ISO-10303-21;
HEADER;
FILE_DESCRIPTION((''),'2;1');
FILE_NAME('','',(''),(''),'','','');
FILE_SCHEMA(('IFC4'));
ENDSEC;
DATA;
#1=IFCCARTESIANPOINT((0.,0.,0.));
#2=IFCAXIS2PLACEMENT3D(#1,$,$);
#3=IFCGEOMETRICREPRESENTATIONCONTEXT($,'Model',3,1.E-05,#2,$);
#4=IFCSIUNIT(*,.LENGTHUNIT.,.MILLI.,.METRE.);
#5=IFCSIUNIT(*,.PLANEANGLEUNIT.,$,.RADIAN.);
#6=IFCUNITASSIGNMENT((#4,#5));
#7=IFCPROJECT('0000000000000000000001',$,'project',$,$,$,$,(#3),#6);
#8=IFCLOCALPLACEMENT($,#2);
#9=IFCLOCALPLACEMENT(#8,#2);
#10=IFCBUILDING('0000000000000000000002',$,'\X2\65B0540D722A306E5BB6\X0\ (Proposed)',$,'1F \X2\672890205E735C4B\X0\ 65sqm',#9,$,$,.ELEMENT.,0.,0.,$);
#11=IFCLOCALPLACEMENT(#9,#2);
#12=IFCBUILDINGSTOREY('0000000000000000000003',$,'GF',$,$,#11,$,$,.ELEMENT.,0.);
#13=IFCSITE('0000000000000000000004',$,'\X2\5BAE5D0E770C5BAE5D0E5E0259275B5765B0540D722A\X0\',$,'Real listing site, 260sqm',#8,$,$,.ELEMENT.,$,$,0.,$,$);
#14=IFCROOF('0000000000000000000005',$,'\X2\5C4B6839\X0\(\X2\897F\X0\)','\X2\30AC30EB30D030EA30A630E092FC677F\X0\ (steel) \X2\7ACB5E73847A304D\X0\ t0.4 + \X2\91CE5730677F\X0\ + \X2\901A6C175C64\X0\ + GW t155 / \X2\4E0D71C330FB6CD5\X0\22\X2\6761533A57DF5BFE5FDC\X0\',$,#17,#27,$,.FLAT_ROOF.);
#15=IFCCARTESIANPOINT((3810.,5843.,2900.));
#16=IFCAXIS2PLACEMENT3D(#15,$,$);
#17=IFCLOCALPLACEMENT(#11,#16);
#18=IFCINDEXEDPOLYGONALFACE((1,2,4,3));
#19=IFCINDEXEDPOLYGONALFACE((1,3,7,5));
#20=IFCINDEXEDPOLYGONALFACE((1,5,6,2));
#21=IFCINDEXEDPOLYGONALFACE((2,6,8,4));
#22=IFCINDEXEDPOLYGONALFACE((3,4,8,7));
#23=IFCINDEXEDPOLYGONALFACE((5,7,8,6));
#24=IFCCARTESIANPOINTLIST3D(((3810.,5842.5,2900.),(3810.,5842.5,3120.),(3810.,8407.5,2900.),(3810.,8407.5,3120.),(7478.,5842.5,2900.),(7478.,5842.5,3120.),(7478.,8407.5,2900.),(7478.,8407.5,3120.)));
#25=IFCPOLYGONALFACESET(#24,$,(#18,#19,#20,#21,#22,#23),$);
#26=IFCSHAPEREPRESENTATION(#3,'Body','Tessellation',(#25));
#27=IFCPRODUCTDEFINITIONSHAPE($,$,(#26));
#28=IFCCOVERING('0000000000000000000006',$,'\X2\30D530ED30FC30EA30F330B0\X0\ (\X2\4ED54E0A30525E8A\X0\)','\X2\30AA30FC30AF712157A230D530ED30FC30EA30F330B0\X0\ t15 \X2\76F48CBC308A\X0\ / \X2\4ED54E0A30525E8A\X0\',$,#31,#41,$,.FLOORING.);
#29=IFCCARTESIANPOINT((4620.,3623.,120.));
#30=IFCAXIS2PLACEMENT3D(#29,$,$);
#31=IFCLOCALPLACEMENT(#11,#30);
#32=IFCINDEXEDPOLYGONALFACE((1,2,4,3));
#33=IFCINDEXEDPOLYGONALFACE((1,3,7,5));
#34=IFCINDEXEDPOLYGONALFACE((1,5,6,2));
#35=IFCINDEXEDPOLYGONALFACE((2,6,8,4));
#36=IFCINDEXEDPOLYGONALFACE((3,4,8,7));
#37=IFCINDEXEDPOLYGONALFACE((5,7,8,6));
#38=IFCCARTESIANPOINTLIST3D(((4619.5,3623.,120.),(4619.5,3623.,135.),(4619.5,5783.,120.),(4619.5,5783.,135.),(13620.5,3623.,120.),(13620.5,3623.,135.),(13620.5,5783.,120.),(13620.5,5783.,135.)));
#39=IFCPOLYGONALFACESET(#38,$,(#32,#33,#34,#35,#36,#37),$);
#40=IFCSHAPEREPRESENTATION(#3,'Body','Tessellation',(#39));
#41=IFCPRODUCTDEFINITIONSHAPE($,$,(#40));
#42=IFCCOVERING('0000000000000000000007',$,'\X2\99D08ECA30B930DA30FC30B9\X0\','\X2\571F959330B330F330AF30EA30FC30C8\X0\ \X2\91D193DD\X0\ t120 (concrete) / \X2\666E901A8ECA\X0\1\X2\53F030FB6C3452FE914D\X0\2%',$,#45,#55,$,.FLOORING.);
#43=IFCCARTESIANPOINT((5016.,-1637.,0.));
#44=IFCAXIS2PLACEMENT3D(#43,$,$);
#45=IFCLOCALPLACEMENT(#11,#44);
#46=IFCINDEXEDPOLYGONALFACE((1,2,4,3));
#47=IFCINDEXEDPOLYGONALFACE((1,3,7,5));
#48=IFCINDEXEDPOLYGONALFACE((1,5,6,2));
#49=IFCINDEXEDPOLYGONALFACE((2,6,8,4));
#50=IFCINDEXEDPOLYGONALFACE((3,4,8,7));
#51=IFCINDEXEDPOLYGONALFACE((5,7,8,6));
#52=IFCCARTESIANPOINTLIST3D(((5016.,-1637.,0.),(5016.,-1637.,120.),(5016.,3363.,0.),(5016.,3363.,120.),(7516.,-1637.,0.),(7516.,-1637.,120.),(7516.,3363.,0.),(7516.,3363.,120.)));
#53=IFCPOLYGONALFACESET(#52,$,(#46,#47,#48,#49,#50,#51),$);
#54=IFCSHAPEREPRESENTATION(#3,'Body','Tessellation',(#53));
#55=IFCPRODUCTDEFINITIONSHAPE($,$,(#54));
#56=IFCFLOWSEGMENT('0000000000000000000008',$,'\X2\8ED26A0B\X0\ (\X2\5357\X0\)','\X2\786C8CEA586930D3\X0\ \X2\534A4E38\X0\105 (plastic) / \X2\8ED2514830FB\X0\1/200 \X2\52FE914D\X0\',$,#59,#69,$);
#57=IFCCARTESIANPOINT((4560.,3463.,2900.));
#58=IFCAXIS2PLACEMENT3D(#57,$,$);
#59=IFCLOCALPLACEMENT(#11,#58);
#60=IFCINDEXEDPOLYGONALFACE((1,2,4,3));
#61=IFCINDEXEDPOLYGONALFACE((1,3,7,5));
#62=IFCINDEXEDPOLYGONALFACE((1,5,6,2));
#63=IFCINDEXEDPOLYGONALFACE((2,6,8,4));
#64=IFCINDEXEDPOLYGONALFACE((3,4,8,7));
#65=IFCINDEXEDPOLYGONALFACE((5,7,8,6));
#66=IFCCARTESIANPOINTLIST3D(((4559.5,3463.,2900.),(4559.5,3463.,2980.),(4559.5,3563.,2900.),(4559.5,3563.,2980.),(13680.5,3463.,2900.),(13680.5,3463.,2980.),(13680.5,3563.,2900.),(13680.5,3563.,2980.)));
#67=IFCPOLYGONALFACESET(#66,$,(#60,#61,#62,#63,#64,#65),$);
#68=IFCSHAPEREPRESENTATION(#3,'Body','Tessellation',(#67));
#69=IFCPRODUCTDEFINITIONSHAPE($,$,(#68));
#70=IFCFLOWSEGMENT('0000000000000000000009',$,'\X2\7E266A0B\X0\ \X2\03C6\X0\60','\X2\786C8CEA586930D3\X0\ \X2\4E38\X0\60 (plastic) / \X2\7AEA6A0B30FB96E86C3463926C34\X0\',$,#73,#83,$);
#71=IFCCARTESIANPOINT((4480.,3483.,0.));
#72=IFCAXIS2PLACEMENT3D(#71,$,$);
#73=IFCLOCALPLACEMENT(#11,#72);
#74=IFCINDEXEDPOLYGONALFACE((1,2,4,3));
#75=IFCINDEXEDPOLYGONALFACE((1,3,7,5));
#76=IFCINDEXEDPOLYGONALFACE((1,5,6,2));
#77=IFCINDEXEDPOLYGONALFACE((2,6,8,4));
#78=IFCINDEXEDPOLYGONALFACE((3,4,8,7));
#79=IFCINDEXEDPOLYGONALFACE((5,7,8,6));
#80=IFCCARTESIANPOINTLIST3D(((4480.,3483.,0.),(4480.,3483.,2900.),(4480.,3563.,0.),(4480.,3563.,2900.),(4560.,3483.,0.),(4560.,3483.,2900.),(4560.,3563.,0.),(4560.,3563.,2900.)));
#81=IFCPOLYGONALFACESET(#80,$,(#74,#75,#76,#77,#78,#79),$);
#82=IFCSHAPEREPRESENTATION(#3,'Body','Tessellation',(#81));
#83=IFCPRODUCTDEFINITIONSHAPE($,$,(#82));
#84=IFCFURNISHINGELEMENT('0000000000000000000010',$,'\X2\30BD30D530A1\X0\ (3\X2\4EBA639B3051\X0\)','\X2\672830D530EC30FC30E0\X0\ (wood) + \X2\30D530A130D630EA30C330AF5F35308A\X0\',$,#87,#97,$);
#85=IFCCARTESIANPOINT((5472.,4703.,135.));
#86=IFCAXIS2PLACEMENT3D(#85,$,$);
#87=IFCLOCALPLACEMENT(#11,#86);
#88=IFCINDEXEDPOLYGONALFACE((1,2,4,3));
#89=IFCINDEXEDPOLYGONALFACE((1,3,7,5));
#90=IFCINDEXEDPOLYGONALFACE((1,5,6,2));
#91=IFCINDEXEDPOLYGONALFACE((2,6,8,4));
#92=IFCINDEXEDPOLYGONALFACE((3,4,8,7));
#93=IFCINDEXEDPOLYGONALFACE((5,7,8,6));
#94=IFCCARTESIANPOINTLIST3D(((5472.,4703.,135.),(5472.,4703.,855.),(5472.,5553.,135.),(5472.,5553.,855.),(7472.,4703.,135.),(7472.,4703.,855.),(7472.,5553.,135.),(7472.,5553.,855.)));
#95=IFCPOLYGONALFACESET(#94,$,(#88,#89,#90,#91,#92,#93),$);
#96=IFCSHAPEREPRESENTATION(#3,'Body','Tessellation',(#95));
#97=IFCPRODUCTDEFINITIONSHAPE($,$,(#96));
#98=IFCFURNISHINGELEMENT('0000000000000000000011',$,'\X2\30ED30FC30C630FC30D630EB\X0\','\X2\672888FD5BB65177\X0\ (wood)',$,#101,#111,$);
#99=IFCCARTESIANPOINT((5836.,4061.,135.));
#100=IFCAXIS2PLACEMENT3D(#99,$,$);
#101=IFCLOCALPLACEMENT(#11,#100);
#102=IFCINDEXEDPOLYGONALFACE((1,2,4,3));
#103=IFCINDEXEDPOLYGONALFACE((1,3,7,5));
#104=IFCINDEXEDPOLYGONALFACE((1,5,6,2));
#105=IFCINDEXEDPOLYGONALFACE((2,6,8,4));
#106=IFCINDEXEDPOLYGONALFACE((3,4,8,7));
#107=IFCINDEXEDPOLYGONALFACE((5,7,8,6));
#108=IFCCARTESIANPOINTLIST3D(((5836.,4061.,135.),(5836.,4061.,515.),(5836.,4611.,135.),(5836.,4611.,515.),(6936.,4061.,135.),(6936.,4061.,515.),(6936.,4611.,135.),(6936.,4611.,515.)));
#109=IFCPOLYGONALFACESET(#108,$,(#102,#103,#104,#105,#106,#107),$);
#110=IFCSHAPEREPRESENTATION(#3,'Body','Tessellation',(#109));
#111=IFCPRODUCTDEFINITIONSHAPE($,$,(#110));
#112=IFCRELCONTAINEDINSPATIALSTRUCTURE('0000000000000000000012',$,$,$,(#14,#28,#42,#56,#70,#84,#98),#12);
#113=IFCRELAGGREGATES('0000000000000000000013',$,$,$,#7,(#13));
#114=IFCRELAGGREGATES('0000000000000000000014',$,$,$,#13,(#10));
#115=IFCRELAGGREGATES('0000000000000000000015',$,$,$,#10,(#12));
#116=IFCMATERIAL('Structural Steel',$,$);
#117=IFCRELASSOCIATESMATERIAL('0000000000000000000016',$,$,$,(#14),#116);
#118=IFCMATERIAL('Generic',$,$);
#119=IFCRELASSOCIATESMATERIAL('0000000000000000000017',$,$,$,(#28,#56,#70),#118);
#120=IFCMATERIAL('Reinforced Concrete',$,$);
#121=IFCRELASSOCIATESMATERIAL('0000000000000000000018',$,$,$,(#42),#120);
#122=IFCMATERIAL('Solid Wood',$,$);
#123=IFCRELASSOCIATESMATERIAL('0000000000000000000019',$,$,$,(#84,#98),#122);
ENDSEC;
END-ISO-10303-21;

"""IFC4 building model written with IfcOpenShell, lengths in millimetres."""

from ifc_helpers import new_model, si_unit, frame, frame_2d, origin, place, context, project, spatial, rectangle, extrude, material, element, save


model = new_model("IFC4")

# Units and contexts
model_context = context("Model", 3, precision=1e-05, world=origin())
ifc_project = project(units=[si_unit("LENGTHUNIT", "METRE", prefix="MILLI"), si_unit("PLANEANGLEUNIT", "RADIAN")], contexts=[model_context])

# Site, building, storey
site_placement = place(None, origin())
site = spatial("IfcSite", under=ifc_project, at=site_placement, Name="宮崎県宮崎市大字新名爪", ObjectType="Real listing site, 260sqm", CompositionType="ELEMENT", RefElevation=0.0)
building_placement = place(site_placement, origin())
building = spatial("IfcBuilding", under=site, at=building_placement, Name="新名爪の家 (Proposed)", ObjectType="1F 木造平屋 65sqm", CompositionType="ELEMENT", ElevationOfRefHeight=0.0, ElevationOfTerrain=0.0)
storey_placement = place(building_placement, origin())
storey = spatial("IfcBuildingStorey", under=building, at=storey_placement, Name="GF", CompositionType="ELEMENT", Elevation=0.0)

# Shared definitions
ifc_material_1 = material(Name="Solid Wood")

# Shared definitions
ifc_material_2 = material(Name="Reinforced Concrete")

# Roof
ifc_material_3 = material(Name="Structural Steel")
roof_1_placement = place(storey_placement, frame((3810.0, 5843.0, 2900.0)))
element("IfcRoof", 1, at=roof_1_placement, inside=storey, material=ifc_material_3, Name="屋根(西)", Description="ガルバリウム鋼板 (steel) 立平葺き t0.4 + 野地板 + 通気層 + GW t155 / 不燃・法22条区域対応", PredefinedType="FLAT_ROOF", context=model_context, shape_type="SweptSolid", body=[
    extrude(rectangle(XDim=3668.0, YDim=2565.0, at=frame_2d((1834.0, 1282.0))), frame((3810.0, 5843.0, 2900.0)), (0.0, 0.0, 1.0), 220.0),
])

# Coverings
ifc_material_4 = material(Name="Generic")
covering_1_placement = place(storey_placement, frame((4620.0, 3623.0, 120.0)))
element("IfcCovering", 2, at=covering_1_placement, inside=storey, material=ifc_material_4, Name="フローリング (仕上げ床)", Description="オーク無垢フローリング t15 直貼り / 仕上げ床", PredefinedType="FLOORING", context=model_context, shape_type="SweptSolid", body=[
    extrude(rectangle(XDim=9001.0, YDim=2160.0, at=frame_2d((4500.0, 1080.0))), frame((4620.0, 3623.0, 120.0)), (0.0, 0.0, 1.0), 15.0),
])
covering_2_placement = place(storey_placement, frame((5016.0, -1637.0, 0.0)))
element("IfcCovering", 3, at=covering_2_placement, inside=storey, material=ifc_material_2, Name="駐車スペース", Description="土間コンクリート 金鏝 t120 (concrete) / 普通車1台・水勾配2%", PredefinedType="FLOORING", context=model_context, shape_type="SweptSolid", body=[
    extrude(rectangle(XDim=2500.0, YDim=5000.0, at=frame_2d((1250.0, 2500.0))), frame((5016.0, -1637.0, 0.0)), (0.0, 0.0, 1.0), 120.0),
])

# Flow segments
flow_segment_1_placement = place(storey_placement, frame((4560.0, 3463.0, 2900.0)))
element("IfcFlowSegment", 4, at=flow_segment_1_placement, inside=storey, material=ifc_material_4, Name="軒樋 (南)", Description="硬質塩ビ 半丸105 (plastic) / 軒先・1/200 勾配", context=model_context, shape_type="SweptSolid", body=[
    extrude(rectangle(XDim=9121.0, YDim=100.0, at=frame_2d((4560.0, 50.0))), frame((4560.0, 3463.0, 2900.0)), (0.0, 0.0, 1.0), 80.0),
])
flow_segment_2_placement = place(storey_placement, frame((4480.0, 3483.0, 0.0)))
element("IfcFlowSegment", 5, at=flow_segment_2_placement, inside=storey, material=ifc_material_4, Name="縦樋 φ60", Description="硬質塩ビ 丸60 (plastic) / 竪樋・雨水排水", context=model_context, shape_type="SweptSolid", body=[
    extrude(rectangle(XDim=80.0, YDim=80.0, at=frame_2d((40.0, 40.0))), frame((4480.0, 3483.0, 0.0)), (0.0, 0.0, 1.0), 2900.0),
])

# Furnishing elements
furnishing_1_placement = place(storey_placement, frame((5472.0, 4703.0, 135.0)))
element("IfcFurnishingElement", 6, at=furnishing_1_placement, inside=storey, material=ifc_material_1, Name="ソファ (3人掛け)", Description="木フレーム (wood) + ファブリック張り", context=model_context, shape_type="SweptSolid", body=[
    extrude(rectangle(XDim=2000.0, YDim=850.0, at=frame_2d((1000.0, 425.0))), frame((5472.0, 4703.0, 135.0)), (0.0, 0.0, 1.0), 720.0),
])
furnishing_2_placement = place(storey_placement, frame((5836.0, 4061.0, 135.0)))
element("IfcFurnishingElement", 7, at=furnishing_2_placement, inside=storey, material=ifc_material_1, Name="ローテーブル", Description="木製家具 (wood)", context=model_context, shape_type="SweptSolid", body=[
    extrude(rectangle(XDim=1100.0, YDim=550.0, at=frame_2d((550.0, 275.0))), frame((5836.0, 4061.0, 135.0)), (0.0, 0.0, 1.0), 380.0),
])

save(model, "model.ifc")
